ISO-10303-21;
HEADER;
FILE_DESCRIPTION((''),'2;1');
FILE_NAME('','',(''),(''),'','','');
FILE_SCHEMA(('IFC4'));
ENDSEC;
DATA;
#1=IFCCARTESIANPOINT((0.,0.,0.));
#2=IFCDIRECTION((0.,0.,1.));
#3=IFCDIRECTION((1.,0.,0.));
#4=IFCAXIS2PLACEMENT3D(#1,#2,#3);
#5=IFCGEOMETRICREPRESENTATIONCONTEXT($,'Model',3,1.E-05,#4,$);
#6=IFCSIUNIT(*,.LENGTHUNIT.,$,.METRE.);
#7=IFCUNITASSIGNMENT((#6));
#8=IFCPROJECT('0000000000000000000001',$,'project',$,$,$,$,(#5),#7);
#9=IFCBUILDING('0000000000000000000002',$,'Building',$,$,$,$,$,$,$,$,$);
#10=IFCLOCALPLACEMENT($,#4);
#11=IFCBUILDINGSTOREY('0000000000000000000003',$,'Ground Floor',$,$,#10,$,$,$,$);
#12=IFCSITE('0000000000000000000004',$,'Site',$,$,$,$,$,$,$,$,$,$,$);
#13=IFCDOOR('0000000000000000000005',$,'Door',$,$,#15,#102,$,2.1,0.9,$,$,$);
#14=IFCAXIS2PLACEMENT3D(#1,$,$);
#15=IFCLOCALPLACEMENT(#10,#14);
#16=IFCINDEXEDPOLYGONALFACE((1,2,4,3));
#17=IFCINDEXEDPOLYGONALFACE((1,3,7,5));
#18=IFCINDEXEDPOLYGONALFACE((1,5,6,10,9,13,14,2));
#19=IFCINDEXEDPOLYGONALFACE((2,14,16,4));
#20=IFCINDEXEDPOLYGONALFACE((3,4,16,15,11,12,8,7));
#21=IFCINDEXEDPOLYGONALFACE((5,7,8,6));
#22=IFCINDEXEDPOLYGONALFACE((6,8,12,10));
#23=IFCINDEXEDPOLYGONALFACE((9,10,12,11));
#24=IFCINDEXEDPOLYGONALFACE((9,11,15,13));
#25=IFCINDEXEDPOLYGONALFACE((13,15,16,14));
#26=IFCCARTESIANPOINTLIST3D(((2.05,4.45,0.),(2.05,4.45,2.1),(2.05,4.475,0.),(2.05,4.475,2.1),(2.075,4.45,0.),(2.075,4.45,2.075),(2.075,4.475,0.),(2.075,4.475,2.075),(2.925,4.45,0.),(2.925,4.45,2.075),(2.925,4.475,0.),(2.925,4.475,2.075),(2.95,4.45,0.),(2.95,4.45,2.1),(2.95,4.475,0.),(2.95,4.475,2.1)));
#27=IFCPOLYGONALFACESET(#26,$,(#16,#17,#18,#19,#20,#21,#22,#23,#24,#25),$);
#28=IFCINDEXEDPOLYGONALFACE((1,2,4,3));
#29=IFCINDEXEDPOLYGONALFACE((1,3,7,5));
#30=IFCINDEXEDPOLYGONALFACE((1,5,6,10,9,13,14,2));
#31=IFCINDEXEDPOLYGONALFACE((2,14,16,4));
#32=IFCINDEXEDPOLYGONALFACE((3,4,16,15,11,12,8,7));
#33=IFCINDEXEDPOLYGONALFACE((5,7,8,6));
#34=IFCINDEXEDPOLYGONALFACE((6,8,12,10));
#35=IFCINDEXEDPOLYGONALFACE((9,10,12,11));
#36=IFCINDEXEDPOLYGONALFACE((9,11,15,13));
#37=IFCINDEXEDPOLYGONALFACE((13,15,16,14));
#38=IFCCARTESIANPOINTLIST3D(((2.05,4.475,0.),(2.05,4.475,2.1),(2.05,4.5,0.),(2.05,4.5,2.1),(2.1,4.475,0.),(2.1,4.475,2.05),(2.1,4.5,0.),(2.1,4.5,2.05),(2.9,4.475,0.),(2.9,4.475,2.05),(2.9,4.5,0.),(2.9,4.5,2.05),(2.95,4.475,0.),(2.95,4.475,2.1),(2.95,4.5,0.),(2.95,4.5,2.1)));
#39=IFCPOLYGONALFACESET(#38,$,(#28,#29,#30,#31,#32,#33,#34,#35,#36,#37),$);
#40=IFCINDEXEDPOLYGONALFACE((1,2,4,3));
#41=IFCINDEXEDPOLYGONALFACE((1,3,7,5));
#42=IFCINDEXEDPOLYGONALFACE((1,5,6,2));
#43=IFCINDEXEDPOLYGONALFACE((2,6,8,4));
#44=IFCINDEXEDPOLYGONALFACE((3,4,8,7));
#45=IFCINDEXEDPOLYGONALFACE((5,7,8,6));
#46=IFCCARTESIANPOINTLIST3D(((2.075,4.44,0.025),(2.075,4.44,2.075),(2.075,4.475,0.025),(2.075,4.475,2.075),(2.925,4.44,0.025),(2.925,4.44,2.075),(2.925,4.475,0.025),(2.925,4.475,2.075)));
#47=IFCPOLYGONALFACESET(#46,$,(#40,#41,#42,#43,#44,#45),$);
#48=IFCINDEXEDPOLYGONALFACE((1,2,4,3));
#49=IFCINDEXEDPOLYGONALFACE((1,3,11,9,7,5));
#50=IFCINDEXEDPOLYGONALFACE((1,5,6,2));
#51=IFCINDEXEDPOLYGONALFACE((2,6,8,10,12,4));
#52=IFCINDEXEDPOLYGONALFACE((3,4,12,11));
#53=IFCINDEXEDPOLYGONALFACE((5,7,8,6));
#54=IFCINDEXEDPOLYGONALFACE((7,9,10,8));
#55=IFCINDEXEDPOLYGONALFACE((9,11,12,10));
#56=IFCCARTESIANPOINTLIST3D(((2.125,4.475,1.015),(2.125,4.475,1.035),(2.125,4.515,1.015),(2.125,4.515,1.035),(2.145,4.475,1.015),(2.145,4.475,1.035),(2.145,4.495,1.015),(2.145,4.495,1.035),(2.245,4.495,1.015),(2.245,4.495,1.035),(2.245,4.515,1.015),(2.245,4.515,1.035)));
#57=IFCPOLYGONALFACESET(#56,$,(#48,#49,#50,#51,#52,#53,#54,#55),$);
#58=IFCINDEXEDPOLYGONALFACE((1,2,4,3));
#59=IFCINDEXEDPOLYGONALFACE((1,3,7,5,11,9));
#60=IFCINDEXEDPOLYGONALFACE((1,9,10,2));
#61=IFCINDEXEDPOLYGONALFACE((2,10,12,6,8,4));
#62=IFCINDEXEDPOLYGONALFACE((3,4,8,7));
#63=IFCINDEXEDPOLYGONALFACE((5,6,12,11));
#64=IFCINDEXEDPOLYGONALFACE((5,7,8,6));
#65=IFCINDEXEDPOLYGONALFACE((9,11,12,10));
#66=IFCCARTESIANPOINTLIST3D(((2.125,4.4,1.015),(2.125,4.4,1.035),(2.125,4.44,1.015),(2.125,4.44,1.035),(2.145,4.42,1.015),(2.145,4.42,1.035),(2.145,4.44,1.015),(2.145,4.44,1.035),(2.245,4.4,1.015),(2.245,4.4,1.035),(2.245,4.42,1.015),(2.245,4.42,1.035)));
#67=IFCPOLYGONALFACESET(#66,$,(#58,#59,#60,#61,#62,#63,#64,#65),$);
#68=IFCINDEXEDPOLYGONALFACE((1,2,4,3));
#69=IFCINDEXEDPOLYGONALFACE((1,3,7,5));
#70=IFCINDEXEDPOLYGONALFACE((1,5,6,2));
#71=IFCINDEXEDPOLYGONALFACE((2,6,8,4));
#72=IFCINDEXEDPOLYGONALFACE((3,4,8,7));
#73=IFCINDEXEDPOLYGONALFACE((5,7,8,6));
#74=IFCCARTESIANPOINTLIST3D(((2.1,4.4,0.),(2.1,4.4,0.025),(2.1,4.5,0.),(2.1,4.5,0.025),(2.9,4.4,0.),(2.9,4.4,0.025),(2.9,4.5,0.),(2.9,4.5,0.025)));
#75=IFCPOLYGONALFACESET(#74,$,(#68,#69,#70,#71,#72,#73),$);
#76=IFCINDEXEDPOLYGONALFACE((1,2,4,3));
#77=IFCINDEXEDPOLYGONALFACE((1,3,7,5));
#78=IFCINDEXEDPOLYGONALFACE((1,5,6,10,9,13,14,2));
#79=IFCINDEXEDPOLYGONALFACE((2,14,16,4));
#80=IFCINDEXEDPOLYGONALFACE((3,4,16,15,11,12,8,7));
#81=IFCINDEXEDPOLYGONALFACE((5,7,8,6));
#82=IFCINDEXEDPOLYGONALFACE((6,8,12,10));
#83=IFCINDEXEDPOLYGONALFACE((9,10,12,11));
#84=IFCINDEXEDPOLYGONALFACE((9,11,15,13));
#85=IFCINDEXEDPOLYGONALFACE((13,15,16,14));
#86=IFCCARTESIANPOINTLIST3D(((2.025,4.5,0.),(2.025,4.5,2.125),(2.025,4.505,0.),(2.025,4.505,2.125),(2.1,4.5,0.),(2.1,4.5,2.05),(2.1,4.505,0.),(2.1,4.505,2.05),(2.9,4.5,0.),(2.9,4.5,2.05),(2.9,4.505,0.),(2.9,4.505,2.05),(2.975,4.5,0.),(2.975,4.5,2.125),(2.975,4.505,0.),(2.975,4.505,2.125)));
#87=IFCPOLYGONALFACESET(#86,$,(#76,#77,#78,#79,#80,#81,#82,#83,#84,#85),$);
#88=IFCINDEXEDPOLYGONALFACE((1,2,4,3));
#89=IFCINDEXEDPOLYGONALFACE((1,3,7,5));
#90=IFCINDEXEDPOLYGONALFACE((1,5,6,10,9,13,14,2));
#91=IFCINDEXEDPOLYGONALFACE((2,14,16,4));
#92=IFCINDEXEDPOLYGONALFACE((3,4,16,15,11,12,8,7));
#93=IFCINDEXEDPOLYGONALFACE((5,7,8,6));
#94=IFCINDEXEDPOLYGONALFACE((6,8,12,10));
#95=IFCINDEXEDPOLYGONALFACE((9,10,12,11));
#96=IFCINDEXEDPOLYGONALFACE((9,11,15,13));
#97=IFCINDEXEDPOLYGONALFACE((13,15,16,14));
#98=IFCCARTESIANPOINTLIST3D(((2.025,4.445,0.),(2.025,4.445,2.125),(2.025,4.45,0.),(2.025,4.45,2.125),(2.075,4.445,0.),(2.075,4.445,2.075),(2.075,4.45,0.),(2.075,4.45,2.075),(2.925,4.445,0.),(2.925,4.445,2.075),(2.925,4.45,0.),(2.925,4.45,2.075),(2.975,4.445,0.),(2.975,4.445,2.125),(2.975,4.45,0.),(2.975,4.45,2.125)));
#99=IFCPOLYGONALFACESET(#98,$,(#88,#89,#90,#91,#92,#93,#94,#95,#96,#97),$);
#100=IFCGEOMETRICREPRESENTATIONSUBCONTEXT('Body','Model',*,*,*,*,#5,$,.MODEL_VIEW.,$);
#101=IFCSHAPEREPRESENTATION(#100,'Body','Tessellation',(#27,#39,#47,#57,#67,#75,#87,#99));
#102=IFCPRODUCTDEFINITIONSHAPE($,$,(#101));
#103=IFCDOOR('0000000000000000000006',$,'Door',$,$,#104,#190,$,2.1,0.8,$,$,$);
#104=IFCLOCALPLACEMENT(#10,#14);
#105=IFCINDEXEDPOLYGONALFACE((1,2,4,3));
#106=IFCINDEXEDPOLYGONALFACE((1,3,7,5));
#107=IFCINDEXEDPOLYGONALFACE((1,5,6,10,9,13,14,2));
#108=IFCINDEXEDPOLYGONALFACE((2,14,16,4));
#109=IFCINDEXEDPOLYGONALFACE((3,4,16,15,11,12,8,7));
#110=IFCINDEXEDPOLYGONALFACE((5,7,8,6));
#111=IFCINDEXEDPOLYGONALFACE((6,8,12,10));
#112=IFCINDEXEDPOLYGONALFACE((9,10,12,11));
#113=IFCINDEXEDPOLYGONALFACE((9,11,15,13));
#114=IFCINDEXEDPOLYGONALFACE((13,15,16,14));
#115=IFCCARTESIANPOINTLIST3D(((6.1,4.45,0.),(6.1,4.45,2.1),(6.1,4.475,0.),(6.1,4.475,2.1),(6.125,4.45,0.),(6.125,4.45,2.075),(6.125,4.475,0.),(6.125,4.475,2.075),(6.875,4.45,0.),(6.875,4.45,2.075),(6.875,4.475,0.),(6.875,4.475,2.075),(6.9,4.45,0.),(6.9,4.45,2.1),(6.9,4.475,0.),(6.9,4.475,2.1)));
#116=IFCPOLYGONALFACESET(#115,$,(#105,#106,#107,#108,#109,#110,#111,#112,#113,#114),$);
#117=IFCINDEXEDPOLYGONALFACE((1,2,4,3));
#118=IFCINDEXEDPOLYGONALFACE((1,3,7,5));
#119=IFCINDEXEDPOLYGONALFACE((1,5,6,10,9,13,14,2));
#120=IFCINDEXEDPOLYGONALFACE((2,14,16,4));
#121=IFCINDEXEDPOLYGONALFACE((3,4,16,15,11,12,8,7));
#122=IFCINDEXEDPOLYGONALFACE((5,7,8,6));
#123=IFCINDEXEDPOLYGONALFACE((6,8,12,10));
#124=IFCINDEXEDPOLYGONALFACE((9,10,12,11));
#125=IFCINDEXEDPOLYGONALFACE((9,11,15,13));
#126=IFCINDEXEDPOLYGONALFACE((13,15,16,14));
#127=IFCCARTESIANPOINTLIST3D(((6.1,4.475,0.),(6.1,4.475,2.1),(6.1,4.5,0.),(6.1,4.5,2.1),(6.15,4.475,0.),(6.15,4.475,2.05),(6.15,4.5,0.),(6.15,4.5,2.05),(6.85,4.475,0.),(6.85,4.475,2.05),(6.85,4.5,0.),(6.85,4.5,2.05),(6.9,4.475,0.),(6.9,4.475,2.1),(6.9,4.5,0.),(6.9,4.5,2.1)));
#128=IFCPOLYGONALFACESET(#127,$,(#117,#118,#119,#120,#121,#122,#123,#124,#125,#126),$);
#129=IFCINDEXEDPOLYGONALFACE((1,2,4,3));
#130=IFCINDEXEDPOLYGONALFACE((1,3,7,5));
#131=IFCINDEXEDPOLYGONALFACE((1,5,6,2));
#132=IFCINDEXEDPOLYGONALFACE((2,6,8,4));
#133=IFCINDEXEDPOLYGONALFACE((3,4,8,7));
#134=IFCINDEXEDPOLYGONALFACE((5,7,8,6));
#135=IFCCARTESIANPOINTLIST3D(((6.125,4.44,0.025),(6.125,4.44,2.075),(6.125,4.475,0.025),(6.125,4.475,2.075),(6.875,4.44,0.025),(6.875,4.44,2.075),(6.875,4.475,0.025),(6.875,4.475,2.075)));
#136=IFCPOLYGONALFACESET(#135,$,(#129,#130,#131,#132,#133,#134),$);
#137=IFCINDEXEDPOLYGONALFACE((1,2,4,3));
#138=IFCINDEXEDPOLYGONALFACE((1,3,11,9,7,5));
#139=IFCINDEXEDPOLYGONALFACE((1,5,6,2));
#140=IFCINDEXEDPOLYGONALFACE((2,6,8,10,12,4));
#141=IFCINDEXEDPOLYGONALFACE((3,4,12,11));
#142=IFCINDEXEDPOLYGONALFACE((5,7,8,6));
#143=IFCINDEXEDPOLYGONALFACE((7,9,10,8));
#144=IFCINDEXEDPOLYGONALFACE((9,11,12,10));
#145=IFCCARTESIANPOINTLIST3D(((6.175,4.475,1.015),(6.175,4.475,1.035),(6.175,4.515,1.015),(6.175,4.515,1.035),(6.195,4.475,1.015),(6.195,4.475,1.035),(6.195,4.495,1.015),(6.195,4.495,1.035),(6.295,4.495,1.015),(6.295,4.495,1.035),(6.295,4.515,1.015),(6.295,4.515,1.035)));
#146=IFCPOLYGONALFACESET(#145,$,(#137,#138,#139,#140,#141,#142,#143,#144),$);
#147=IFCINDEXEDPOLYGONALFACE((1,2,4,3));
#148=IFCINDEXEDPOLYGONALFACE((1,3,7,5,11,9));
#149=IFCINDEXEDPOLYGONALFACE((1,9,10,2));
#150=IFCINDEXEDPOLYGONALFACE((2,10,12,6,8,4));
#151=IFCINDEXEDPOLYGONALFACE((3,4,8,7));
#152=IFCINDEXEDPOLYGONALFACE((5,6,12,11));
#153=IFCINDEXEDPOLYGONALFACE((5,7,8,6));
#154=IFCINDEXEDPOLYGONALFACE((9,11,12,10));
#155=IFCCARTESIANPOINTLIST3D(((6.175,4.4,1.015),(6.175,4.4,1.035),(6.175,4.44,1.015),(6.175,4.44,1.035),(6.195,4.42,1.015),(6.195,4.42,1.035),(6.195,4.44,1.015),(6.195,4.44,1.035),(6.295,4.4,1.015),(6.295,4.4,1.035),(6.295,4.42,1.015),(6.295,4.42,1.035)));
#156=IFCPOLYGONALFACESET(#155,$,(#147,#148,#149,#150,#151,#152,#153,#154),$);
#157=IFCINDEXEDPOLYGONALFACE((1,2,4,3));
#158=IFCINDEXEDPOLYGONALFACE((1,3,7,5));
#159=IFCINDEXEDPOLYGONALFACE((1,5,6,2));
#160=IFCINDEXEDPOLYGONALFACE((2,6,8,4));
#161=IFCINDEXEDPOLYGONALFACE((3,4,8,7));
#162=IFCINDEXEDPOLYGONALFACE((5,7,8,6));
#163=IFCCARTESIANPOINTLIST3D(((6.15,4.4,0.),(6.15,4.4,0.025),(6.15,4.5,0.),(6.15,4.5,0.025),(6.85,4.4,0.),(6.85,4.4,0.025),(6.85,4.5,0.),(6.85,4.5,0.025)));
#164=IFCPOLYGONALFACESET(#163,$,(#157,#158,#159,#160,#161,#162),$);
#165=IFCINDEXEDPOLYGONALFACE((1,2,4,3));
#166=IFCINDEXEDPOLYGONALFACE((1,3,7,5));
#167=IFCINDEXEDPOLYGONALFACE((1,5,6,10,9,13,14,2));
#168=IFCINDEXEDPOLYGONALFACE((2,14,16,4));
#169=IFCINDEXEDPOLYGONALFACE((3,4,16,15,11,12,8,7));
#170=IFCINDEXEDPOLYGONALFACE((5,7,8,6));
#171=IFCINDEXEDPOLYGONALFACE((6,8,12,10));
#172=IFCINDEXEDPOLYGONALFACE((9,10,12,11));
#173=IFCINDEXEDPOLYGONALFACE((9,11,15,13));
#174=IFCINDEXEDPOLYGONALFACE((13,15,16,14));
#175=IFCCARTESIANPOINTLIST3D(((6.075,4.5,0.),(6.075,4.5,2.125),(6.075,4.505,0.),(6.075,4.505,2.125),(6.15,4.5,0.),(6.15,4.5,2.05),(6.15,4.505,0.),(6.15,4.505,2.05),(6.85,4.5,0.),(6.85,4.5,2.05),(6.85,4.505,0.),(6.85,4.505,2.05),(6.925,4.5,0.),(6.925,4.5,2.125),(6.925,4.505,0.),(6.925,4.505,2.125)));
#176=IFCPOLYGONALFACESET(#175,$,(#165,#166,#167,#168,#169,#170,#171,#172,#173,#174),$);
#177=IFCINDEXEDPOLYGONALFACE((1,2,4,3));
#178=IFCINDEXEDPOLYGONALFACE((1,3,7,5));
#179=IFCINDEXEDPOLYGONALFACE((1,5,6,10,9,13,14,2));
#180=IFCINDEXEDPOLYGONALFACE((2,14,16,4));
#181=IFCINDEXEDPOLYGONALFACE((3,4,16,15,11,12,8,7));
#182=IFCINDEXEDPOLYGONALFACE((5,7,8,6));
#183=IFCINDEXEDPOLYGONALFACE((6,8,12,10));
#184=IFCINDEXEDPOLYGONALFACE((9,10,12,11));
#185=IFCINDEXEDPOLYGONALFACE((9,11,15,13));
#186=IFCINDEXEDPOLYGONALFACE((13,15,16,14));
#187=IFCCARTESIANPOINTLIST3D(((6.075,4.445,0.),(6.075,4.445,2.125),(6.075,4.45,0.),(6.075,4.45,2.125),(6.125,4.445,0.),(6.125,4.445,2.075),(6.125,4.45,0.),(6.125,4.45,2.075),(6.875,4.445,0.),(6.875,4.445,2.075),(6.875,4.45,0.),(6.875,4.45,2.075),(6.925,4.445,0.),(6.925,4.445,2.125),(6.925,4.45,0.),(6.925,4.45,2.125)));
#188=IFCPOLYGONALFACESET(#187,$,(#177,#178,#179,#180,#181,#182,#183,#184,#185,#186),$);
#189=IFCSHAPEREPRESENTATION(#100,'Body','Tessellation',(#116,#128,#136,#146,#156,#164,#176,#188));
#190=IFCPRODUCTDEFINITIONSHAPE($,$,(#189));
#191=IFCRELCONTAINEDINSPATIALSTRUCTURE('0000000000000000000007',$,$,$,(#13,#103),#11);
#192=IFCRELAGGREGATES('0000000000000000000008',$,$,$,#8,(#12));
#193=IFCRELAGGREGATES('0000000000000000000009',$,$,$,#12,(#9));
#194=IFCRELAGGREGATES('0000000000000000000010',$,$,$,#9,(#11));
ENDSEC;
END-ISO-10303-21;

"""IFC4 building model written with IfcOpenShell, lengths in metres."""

from ifc_helpers import new_model, si_unit, frame, origin_with_axes, place, context, subcontext, project, spatial, line, indexed_curve, outline, extrude, element, save


model = new_model("IFC4")

# Units and contexts
model_context = context("Model", 3, precision=1e-05, world=origin_with_axes())
body_context = subcontext(model_context, "Body", "Model", "MODEL_VIEW")
ifc_project = project(units=[si_unit("LENGTHUNIT", "METRE")], contexts=[model_context])

# Site, building, storey
site = spatial("IfcSite", under=ifc_project, Name="Site")
building = spatial("IfcBuilding", under=site, Name="Building")
storey_placement = place(None, origin_with_axes())
storey = spatial("IfcBuildingStorey", under=building, at=storey_placement, Name="Ground Floor")

# Doors
door_1_placement = place(storey_placement, frame((2.95, 4.5, 0.0), z_axis=(0.0, 0.0, 1.0), x_axis=(-1.0, 0.0, 0.0)))
element("IfcDoor", 1, at=door_1_placement, inside=storey, Name="Door", OverallHeight=2.1, OverallWidth=0.9, context=body_context, shape_type="SweptSolid", body=[
    extrude(outline(indexed_curve([(0.0, 0.0), (0.0, 2.1), (0.9, 2.1), (0.9, 0.0), (0.875, 0.0), (0.875, 2.075), (0.025, 2.075), (0.025, 0.0)], segments=[line(1, 2, 3, 4, 5, 6, 7, 8, 1)])), frame((0.0, 0.025, 0.0), z_axis=(0.0, -1.0, 0.0), x_axis=(1.0, 0.0, 0.0)), (0.0, 0.0, -1.0), 0.025),
    extrude(outline(indexed_curve([(0.0, 0.0), (0.0, 2.1), (0.9, 2.1), (0.9, 0.0), (0.85, 0.0), (0.85, 2.05), (0.05, 2.05), (0.05, 0.0)], segments=[line(1, 2, 3, 4, 5, 6, 7, 8, 1)])), frame((0.0, 0.0, 0.0), z_axis=(0.0, -1.0, 0.0), x_axis=(1.0, 0.0, 0.0)), (0.0, 0.0, -1.0), 0.025),
    extrude(outline(indexed_curve([(0.0, 0.0), (0.85, 0.0), (0.85, 0.035), (0.0, 0.035)], segments=[line(1, 2, 3, 4, 1)])), frame((0.025, 0.025, 0.025), z_axis=(0.0, 0.0, 1.0), x_axis=(1.0, 0.0, 0.0)), (0.0, 0.0, 1.0), 2.05),
    extrude(outline(indexed_curve([(0.0, 0.0), (0.0, -0.04), (-0.12, -0.04), (-0.12, -0.02), (-0.02, -0.02), (-0.02, 0.0)], segments=[line(1, 2, 3, 4, 5, 6, 1)])), frame((0.825, 0.025, 1.015), z_axis=(0.0, 0.0, 1.0), x_axis=(1.0, 0.0, 0.0)), (0.0, 0.0, 1.0), 0.02),
    extrude(outline(indexed_curve([(0.0, 0.0), (0.0, 0.04), (-0.12, 0.04), (-0.12, 0.02), (-0.02, 0.02), (-0.02, 0.0)], segments=[line(1, 2, 3, 4, 5, 6, 1)])), frame((0.825, 0.06, 1.015), z_axis=(0.0, 0.0, 1.0), x_axis=(1.0, 0.0, 0.0)), (0.0, 0.0, 1.0), 0.02),
    extrude(outline(indexed_curve([(0.0, 0.0), (0.8, 0.0), (0.8, 0.1), (0.0, 0.1)], segments=[line(1, 2, 3, 4, 1)])), frame((0.05, 0.0, 0.0), z_axis=(0.0, 0.0, 1.0), x_axis=(1.0, 0.0, 0.0)), (0.0, 0.0, 1.0), 0.025),
    extrude(outline(indexed_curve([(0.0, 0.0), (0.0, 2.125), (0.95, 2.125), (0.95, 0.0), (0.875, 0.0), (0.875, 2.05), (0.075, 2.05), (0.075, 0.0)], segments=[line(1, 2, 3, 4, 5, 6, 7, 8, 1)])), frame((-0.025, -0.005, 0.0), z_axis=(0.0, -1.0, 0.0), x_axis=(1.0, 0.0, 0.0)), (0.0, 0.0, -1.0), 0.005),
    extrude(outline(indexed_curve([(0.0, 0.0), (0.0, 2.125), (0.95, 2.125), (0.95, 0.0), (0.9, 0.0), (0.9, 2.075), (0.05, 2.075), (0.05, 0.0)], segments=[line(1, 2, 3, 4, 5, 6, 7, 8, 1)])), frame((-0.025, 0.05, 0.0), z_axis=(0.0, -1.0, 0.0), x_axis=(1.0, 0.0, 0.0)), (0.0, 0.0, -1.0), 0.005),
])
door_2_placement = place(storey_placement, frame((6.9, 4.5, 0.0), z_axis=(0.0, 0.0, 1.0), x_axis=(-1.0, 0.0, 0.0)))
element("IfcDoor", 2, at=door_2_placement, inside=storey, Name="Door", OverallHeight=2.1, OverallWidth=0.8, context=body_context, shape_type="SweptSolid", body=[
    extrude(outline(indexed_curve([(0.0, 0.0), (0.0, 2.1), (0.8, 2.1), (0.8, 0.0), (0.775, 0.0), (0.775, 2.075), (0.025, 2.075), (0.025, 0.0)], segments=[line(1, 2, 3, 4, 5, 6, 7, 8, 1)])), frame((0.0, 0.025, 0.0), z_axis=(0.0, -1.0, 0.0), x_axis=(1.0, 0.0, 0.0)), (0.0, 0.0, -1.0), 0.025),
    extrude(outline(indexed_curve([(0.0, 0.0), (0.0, 2.1), (0.8, 2.1), (0.8, 0.0), (0.75, 0.0), (0.75, 2.05), (0.05, 2.05), (0.05, 0.0)], segments=[line(1, 2, 3, 4, 5, 6, 7, 8, 1)])), frame((0.0, 0.0, 0.0), z_axis=(0.0, -1.0, 0.0), x_axis=(1.0, 0.0, 0.0)), (0.0, 0.0, -1.0), 0.025),
    extrude(outline(indexed_curve([(0.0, 0.0), (0.75, 0.0), (0.75, 0.035), (0.0, 0.035)], segments=[line(1, 2, 3, 4, 1)])), frame((0.025, 0.025, 0.025), z_axis=(0.0, 0.0, 1.0), x_axis=(1.0, 0.0, 0.0)), (0.0, 0.0, 1.0), 2.05),
    extrude(outline(indexed_curve([(0.0, 0.0), (0.0, -0.04), (-0.12, -0.04), (-0.12, -0.02), (-0.02, -0.02), (-0.02, 0.0)], segments=[line(1, 2, 3, 4, 5, 6, 1)])), frame((0.725, 0.025, 1.015), z_axis=(0.0, 0.0, 1.0), x_axis=(1.0, 0.0, 0.0)), (0.0, 0.0, 1.0), 0.02),
    extrude(outline(indexed_curve([(0.0, 0.0), (0.0, 0.04), (-0.12, 0.04), (-0.12, 0.02), (-0.02, 0.02), (-0.02, 0.0)], segments=[line(1, 2, 3, 4, 5, 6, 1)])), frame((0.725, 0.06, 1.015), z_axis=(0.0, 0.0, 1.0), x_axis=(1.0, 0.0, 0.0)), (0.0, 0.0, 1.0), 0.02),
    extrude(outline(indexed_curve([(0.0, 0.0), (0.7, 0.0), (0.7, 0.1), (0.0, 0.1)], segments=[line(1, 2, 3, 4, 1)])), frame((0.05, 0.0, 0.0), z_axis=(0.0, 0.0, 1.0), x_axis=(1.0, 0.0, 0.0)), (0.0, 0.0, 1.0), 0.025),
    extrude(outline(indexed_curve([(0.0, 0.0), (0.0, 2.125), (0.85, 2.125), (0.85, 0.0), (0.775, 0.0), (0.775, 2.05), (0.075, 2.05), (0.075, 0.0)], segments=[line(1, 2, 3, 4, 5, 6, 7, 8, 1)])), frame((-0.025, -0.005, 0.0), z_axis=(0.0, -1.0, 0.0), x_axis=(1.0, 0.0, 0.0)), (0.0, 0.0, -1.0), 0.005),
    extrude(outline(indexed_curve([(0.0, 0.0), (0.0, 2.125), (0.85, 2.125), (0.85, 0.0), (0.8, 0.0), (0.8, 2.075), (0.05, 2.075), (0.05, 0.0)], segments=[line(1, 2, 3, 4, 5, 6, 7, 8, 1)])), frame((-0.025, 0.05, 0.0), z_axis=(0.0, -1.0, 0.0), x_axis=(1.0, 0.0, 0.0)), (0.0, 0.0, -1.0), 0.005),
])

save(model, "model.ifc")
